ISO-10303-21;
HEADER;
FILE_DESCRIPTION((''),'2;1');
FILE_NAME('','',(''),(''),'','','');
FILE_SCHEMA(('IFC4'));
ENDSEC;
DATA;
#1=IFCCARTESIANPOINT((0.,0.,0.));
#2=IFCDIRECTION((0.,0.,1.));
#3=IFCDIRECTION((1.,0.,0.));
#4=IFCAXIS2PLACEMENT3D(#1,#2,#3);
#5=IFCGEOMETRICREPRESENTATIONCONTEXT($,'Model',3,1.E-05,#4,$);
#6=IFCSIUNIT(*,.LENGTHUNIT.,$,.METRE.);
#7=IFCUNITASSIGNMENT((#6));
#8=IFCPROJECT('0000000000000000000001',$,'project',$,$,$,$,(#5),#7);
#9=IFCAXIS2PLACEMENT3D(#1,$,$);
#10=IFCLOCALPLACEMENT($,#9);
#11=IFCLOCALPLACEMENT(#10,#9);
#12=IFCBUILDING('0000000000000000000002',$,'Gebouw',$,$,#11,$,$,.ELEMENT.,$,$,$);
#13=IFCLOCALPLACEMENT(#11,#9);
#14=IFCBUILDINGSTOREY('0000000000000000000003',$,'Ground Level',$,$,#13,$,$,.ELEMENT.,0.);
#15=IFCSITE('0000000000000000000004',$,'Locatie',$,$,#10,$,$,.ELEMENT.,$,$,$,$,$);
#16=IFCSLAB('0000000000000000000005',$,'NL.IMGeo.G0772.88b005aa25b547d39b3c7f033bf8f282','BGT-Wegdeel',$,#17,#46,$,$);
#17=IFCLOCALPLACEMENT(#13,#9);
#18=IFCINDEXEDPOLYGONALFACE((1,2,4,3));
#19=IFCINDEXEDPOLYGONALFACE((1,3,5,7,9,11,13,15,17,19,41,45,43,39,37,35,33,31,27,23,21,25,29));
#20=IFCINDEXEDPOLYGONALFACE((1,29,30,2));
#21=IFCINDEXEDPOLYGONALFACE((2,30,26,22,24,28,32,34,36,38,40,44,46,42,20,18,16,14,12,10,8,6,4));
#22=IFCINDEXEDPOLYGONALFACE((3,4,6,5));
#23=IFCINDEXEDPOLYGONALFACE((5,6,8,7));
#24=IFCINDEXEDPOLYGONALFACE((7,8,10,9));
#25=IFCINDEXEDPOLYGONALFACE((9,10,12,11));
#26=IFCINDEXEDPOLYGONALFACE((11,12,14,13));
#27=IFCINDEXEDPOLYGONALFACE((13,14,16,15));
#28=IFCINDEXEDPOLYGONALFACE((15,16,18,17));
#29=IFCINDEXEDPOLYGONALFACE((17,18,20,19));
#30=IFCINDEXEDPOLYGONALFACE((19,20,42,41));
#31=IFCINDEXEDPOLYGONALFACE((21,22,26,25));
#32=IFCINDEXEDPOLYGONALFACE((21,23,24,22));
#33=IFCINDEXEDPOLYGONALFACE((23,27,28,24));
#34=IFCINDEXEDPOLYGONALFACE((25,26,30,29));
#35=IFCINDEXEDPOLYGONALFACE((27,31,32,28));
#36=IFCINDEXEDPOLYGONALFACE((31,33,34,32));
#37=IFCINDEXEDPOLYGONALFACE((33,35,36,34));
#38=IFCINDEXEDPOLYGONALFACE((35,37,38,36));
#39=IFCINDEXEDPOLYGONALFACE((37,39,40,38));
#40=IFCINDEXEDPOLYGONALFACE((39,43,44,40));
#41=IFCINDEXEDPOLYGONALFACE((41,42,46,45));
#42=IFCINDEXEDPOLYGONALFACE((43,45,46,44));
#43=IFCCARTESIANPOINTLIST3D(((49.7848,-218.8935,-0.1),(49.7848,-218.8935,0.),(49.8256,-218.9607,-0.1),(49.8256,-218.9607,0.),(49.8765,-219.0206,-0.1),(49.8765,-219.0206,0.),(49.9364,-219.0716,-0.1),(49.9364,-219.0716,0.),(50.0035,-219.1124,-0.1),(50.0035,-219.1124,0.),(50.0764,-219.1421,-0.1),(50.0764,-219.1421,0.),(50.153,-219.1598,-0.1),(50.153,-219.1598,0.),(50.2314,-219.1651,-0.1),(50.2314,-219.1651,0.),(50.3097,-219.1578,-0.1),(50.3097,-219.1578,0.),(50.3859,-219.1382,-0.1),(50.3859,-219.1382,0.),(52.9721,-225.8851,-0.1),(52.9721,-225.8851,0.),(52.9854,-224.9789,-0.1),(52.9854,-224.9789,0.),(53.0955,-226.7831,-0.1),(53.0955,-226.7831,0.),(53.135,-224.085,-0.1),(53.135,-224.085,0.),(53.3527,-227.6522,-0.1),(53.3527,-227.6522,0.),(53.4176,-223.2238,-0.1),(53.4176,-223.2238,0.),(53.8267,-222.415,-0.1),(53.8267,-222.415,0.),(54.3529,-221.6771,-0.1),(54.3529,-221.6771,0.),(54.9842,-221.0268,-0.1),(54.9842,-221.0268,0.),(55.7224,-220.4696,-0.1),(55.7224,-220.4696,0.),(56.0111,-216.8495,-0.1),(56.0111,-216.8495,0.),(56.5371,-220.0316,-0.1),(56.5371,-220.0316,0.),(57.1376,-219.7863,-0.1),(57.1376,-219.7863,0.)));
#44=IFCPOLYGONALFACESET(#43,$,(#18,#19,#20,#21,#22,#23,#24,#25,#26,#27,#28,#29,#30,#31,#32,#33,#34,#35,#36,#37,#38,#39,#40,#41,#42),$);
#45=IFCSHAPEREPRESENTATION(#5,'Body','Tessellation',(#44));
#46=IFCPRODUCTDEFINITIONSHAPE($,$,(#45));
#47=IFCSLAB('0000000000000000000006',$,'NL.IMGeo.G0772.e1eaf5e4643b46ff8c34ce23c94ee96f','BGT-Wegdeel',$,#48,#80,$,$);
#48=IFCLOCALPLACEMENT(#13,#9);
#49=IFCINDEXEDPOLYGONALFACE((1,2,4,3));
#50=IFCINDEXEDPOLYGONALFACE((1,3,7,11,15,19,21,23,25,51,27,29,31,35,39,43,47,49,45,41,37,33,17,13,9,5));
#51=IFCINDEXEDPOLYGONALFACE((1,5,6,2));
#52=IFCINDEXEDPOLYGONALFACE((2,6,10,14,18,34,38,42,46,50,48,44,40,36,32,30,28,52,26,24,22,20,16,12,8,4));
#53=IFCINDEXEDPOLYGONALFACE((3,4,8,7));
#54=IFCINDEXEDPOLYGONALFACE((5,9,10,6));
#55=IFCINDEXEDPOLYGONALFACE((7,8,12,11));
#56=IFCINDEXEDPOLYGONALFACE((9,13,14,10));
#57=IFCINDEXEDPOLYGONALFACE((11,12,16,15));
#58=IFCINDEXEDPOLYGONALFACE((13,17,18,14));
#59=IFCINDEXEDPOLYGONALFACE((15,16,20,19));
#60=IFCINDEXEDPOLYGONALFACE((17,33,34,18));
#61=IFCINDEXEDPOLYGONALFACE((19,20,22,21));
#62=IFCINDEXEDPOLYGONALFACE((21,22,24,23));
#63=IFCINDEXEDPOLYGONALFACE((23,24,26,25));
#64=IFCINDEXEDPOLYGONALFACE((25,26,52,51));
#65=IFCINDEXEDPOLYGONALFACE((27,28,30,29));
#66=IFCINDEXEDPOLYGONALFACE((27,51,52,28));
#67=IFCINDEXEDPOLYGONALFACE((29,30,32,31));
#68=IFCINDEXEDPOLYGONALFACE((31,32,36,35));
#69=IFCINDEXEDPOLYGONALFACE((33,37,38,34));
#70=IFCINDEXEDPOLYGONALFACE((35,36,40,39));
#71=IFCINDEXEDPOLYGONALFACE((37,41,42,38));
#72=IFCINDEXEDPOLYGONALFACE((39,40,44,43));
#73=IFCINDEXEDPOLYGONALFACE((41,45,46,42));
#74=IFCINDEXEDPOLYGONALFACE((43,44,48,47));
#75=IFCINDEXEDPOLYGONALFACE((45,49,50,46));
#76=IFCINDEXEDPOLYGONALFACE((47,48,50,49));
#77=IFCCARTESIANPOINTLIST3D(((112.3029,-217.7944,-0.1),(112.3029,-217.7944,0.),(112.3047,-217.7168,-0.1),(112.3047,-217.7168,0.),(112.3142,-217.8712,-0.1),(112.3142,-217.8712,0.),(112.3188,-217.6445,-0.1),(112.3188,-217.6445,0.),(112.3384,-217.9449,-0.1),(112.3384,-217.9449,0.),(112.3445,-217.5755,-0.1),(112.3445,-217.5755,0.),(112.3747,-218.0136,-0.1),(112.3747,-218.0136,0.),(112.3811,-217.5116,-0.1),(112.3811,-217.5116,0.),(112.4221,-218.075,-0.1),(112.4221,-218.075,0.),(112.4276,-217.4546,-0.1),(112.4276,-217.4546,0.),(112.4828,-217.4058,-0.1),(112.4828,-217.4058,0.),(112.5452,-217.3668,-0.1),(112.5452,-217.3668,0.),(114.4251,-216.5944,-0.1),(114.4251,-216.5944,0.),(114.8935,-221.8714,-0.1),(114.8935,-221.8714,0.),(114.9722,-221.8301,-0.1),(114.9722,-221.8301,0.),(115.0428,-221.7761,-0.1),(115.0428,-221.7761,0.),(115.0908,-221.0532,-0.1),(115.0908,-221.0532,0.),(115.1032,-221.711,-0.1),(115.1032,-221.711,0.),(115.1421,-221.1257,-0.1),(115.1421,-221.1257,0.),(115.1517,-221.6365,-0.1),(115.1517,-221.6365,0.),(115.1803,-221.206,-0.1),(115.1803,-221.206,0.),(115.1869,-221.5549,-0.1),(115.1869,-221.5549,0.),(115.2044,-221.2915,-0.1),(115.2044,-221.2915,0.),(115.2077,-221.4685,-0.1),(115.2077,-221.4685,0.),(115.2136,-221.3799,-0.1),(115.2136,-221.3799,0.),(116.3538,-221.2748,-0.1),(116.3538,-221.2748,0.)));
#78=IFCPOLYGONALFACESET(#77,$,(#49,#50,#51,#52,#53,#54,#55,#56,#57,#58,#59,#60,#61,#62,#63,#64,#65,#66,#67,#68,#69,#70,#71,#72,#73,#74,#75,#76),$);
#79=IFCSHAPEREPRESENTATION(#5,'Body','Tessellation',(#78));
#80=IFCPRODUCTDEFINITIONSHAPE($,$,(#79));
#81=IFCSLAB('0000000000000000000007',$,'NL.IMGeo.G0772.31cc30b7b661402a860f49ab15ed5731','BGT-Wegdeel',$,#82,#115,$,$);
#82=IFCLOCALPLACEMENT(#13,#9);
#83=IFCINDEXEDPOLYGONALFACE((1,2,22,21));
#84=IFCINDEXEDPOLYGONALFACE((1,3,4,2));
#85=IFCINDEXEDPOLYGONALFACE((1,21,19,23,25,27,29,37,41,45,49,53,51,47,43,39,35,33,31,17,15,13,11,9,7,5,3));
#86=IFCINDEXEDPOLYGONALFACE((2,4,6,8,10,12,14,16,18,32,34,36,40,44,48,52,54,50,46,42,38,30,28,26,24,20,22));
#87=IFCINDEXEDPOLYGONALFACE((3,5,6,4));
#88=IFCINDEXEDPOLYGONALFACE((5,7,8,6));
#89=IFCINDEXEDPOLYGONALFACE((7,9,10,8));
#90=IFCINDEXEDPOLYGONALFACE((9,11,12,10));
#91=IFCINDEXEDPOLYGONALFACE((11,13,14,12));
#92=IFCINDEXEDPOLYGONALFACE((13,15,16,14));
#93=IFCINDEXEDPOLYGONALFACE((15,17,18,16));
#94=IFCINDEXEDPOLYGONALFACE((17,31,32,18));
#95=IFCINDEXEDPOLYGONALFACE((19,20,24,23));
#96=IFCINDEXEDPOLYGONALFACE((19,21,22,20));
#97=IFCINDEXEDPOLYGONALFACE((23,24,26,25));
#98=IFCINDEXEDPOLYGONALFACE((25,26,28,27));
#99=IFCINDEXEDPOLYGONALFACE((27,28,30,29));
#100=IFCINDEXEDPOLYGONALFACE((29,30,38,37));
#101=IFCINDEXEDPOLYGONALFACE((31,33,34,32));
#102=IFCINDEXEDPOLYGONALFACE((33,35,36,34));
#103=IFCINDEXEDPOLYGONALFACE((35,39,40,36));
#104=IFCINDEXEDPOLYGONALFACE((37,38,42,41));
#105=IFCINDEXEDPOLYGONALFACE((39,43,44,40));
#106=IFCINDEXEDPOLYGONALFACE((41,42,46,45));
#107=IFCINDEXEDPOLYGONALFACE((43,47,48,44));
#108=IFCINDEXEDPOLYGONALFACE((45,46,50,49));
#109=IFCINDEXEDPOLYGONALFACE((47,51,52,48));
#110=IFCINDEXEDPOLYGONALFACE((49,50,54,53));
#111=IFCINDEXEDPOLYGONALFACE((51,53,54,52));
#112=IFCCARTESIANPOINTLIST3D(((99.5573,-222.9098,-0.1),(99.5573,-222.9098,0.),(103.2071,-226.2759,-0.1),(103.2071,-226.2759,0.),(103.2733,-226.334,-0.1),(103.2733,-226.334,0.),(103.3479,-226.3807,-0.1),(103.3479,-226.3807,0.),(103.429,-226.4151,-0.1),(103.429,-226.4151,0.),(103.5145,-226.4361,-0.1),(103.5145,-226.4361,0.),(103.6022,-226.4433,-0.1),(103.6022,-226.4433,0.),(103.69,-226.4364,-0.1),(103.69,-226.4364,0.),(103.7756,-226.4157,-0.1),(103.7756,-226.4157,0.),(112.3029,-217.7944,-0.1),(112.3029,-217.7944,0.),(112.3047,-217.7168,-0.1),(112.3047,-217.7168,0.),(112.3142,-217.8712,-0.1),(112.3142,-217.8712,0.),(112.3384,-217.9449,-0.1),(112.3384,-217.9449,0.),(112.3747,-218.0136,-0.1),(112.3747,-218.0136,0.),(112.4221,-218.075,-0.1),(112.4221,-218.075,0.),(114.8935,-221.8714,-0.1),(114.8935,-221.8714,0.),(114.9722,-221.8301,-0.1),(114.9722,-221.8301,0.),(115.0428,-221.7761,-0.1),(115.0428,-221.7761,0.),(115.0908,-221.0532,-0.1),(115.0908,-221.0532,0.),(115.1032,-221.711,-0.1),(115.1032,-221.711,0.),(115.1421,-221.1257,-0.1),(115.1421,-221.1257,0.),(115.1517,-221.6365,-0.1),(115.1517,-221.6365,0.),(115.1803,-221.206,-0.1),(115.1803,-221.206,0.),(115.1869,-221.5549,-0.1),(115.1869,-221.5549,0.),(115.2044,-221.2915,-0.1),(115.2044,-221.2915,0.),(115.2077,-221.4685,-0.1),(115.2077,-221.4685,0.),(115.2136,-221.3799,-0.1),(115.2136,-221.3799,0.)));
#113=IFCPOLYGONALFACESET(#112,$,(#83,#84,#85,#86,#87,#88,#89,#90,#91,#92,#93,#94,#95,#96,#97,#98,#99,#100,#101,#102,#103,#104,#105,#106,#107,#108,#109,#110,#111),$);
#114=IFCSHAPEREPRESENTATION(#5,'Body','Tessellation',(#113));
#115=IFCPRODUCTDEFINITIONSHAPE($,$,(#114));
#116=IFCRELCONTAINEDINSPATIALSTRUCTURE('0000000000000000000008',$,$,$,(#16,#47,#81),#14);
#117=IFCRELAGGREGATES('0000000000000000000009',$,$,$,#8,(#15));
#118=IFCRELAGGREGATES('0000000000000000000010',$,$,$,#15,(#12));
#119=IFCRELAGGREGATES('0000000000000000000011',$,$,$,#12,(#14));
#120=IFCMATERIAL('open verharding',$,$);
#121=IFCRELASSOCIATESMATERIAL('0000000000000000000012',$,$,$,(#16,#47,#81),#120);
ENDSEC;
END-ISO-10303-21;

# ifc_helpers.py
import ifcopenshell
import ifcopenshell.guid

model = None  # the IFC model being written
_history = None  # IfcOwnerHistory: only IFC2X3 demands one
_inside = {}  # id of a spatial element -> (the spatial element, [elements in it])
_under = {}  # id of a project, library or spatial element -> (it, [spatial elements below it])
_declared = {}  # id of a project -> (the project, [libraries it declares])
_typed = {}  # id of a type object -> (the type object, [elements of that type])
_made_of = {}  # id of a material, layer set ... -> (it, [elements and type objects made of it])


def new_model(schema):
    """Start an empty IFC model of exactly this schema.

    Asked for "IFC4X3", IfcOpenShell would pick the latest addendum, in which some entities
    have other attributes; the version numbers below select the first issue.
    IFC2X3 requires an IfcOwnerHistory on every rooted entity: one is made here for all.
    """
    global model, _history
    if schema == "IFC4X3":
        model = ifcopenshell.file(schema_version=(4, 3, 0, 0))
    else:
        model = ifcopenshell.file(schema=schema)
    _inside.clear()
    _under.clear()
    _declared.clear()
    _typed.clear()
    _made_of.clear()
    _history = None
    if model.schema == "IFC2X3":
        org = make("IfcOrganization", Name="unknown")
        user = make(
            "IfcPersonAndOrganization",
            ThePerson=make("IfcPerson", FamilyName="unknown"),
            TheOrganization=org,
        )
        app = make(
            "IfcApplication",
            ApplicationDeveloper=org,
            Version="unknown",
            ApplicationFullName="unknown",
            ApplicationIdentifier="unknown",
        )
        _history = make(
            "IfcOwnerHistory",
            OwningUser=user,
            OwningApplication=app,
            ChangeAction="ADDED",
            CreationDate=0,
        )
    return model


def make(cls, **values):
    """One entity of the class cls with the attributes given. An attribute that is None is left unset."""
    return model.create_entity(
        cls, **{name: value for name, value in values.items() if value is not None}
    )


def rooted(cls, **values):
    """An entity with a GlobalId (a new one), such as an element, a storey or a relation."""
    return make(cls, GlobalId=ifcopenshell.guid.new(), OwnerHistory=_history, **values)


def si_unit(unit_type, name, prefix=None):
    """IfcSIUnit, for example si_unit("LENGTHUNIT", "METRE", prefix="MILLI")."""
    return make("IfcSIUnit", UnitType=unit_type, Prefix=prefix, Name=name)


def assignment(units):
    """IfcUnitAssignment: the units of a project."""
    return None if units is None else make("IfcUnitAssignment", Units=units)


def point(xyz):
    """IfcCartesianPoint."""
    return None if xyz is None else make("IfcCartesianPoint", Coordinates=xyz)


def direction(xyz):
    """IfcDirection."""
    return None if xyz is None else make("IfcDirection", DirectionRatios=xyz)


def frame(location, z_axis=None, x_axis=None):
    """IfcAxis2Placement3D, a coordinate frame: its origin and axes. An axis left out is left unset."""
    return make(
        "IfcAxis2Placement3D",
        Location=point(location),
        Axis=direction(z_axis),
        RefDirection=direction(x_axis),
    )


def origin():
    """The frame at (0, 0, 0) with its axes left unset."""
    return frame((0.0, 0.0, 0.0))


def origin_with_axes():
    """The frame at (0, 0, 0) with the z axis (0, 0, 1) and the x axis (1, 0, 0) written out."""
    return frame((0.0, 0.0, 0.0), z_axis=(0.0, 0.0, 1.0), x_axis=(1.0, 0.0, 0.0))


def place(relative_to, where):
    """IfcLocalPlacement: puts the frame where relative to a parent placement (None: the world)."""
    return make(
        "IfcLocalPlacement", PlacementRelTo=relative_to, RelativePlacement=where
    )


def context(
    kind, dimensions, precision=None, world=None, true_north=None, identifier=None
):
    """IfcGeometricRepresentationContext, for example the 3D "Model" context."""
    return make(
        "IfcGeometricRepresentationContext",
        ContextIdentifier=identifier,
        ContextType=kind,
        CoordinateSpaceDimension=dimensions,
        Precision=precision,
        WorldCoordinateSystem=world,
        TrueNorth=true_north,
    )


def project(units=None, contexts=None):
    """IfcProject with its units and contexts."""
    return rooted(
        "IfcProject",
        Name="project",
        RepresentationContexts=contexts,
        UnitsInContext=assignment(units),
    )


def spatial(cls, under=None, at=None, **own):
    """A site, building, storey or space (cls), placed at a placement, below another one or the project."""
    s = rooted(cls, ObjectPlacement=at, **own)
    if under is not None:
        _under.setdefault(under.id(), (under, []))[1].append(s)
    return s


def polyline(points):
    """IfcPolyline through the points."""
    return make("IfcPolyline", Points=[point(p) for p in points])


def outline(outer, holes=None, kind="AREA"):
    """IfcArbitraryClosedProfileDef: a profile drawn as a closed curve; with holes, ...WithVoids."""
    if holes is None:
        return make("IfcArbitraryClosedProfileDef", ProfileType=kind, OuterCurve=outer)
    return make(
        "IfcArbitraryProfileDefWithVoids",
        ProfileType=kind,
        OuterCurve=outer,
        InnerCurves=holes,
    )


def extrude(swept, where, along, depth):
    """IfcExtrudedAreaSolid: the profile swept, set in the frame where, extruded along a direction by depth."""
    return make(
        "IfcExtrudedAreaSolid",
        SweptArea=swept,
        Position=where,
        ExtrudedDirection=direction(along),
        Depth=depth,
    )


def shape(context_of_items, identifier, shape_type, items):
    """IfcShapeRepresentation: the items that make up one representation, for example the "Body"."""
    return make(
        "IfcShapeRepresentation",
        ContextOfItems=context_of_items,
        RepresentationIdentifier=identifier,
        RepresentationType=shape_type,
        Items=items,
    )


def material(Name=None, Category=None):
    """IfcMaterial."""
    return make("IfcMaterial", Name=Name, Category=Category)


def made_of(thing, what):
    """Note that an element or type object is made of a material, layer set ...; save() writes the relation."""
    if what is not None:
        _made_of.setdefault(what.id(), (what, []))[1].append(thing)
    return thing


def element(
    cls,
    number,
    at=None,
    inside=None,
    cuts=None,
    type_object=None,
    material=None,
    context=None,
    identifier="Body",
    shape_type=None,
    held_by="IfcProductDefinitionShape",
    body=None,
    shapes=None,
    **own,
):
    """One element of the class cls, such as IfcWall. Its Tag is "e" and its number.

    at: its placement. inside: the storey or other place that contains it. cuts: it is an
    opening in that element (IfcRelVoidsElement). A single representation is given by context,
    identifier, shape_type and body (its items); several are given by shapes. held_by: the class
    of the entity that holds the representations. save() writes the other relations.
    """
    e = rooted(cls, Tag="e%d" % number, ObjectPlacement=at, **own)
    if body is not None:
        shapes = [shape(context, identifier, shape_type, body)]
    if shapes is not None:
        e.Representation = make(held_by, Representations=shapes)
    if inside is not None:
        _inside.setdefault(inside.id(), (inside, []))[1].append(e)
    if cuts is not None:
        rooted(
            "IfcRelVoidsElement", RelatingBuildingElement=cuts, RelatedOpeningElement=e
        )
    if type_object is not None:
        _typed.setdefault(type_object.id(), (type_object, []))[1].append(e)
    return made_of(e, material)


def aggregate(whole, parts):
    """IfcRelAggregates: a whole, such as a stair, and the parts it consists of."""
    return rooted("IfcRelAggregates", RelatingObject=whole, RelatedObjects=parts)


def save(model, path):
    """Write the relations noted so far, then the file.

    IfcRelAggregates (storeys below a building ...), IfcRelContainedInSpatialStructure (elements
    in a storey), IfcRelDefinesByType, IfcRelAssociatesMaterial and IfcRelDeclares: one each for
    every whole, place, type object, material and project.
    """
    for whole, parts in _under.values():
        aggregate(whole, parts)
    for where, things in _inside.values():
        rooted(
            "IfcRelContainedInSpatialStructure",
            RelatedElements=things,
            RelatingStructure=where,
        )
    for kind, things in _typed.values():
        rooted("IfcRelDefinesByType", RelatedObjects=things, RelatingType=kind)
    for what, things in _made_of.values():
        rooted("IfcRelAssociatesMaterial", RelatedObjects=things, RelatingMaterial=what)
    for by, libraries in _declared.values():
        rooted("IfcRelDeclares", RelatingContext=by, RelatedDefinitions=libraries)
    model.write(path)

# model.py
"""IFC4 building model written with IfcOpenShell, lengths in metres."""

from ifc_helpers import new_model, si_unit, frame, origin, origin_with_axes, place, context, project, spatial, polyline, outline, extrude, material, element, save


model = new_model("IFC4")

# Units and contexts
model_context = context("Model", 3, precision=1e-05, world=origin_with_axes())
ifc_project = project(units=[si_unit("LENGTHUNIT", "METRE")], contexts=[model_context])

# Site, building, storey
site_placement = place(None, origin())
site = spatial("IfcSite", under=ifc_project, at=site_placement, Name="Locatie", CompositionType="ELEMENT")
building_placement = place(site_placement, origin())
building = spatial("IfcBuilding", under=site, at=building_placement, Name="Gebouw", CompositionType="ELEMENT")
storey_placement = place(building_placement, origin())
storey = spatial("IfcBuildingStorey", under=building, at=storey_placement, Name="Ground Level", CompositionType="ELEMENT", Elevation=0.0)

# Slabs
ifc_material_1 = material(Name="open verharding")
slab_1_placement = place(storey_placement, origin())
element("IfcSlab", 1, at=slab_1_placement, inside=storey, material=ifc_material_1, Name="NL.IMGeo.G0772.88b005aa25b547d39b3c7f033bf8f282", Description="BGT-Wegdeel", context=model_context, shape_type="SweptSolid", body=[
    extrude(outline(polyline([(57.1376, -219.7863), (56.5371, -220.0316), (55.7224, -220.4696), (54.9842, -221.0268), (54.3529, -221.6771), (53.8267, -222.415), (53.4176, -223.2238), (53.135, -224.085), (52.9854, -224.9789), (52.9721, -225.8851), (53.0955, -226.7831), (53.3527, -227.6522), (49.7848, -218.8935), (49.8256, -218.9607), (49.8765, -219.0206), (49.9364, -219.0716), (50.0035, -219.1124), (50.0764, -219.1421), (50.153, -219.1598), (50.2314, -219.1651), (50.3097, -219.1578), (50.3859, -219.1382), (56.0111, -216.8495), (57.1376, -219.7863)])), frame((0.0, 0.0, -0.1), z_axis=(0.0, 0.0, 1.0), x_axis=(1.0, 0.0, 0.0)), (0.0, 0.0, 1.0), 0.1),
])
slab_2_placement = place(storey_placement, origin())
element("IfcSlab", 2, at=slab_2_placement, inside=storey, material=ifc_material_1, Name="NL.IMGeo.G0772.e1eaf5e4643b46ff8c34ce23c94ee96f", Description="BGT-Wegdeel", context=model_context, shape_type="SweptSolid", body=[
    extrude(outline(polyline([(116.3538, -221.2748), (114.8935, -221.8714), (114.9722, -221.8301), (115.0428, -221.7761), (115.1032, -221.711), (115.1517, -221.6365), (115.1869, -221.5549), (115.2077, -221.4685), (115.2136, -221.3799), (115.2044, -221.2915), (115.1803, -221.206), (115.1421, -221.1257), (115.0908, -221.0532), (112.4221, -218.075), (112.3747, -218.0136), (112.3384, -217.9449), (112.3142, -217.8712), (112.3029, -217.7944), (112.3047, -217.7168), (112.3188, -217.6445), (112.3445, -217.5755), (112.3811, -217.5116), (112.4276, -217.4546), (112.4828, -217.4058), (112.5452, -217.3668), (114.4251, -216.5944), (116.3538, -221.2748)])), frame((0.0, 0.0, -0.1), z_axis=(0.0, 0.0, 1.0), x_axis=(1.0, 0.0, 0.0)), (0.0, 0.0, 1.0), 0.1),
])
slab_3_placement = place(storey_placement, origin())
element("IfcSlab", 3, at=slab_3_placement, inside=storey, material=ifc_material_1, Name="NL.IMGeo.G0772.31cc30b7b661402a860f49ab15ed5731", Description="BGT-Wegdeel", context=model_context, shape_type="SweptSolid", body=[
    extrude(outline(polyline([(112.3047, -217.7168), (112.3029, -217.7944), (112.3142, -217.8712), (112.3384, -217.9449), (112.3747, -218.0136), (112.4221, -218.075), (115.0908, -221.0532), (115.1421, -221.1257), (115.1803, -221.206), (115.2044, -221.2915), (115.2136, -221.3799), (115.2077, -221.4685), (115.1869, -221.5549), (115.1517, -221.6365), (115.1032, -221.711), (115.0428, -221.7761), (114.9722, -221.8301), (114.8935, -221.8714), (103.7756, -226.4157), (103.69, -226.4364), (103.6022, -226.4433), (103.5145, -226.4361), (103.429, -226.4151), (103.3479, -226.3807), (103.2733, -226.334), (103.2071, -226.2759), (99.5573, -222.9098), (112.3047, -217.7168)])), frame((0.0, 0.0, -0.1), z_axis=(0.0, 0.0, 1.0), x_axis=(1.0, 0.0, 0.0)), (0.0, 0.0, 1.0), 0.1),
])

save(model, "model.ifc")
